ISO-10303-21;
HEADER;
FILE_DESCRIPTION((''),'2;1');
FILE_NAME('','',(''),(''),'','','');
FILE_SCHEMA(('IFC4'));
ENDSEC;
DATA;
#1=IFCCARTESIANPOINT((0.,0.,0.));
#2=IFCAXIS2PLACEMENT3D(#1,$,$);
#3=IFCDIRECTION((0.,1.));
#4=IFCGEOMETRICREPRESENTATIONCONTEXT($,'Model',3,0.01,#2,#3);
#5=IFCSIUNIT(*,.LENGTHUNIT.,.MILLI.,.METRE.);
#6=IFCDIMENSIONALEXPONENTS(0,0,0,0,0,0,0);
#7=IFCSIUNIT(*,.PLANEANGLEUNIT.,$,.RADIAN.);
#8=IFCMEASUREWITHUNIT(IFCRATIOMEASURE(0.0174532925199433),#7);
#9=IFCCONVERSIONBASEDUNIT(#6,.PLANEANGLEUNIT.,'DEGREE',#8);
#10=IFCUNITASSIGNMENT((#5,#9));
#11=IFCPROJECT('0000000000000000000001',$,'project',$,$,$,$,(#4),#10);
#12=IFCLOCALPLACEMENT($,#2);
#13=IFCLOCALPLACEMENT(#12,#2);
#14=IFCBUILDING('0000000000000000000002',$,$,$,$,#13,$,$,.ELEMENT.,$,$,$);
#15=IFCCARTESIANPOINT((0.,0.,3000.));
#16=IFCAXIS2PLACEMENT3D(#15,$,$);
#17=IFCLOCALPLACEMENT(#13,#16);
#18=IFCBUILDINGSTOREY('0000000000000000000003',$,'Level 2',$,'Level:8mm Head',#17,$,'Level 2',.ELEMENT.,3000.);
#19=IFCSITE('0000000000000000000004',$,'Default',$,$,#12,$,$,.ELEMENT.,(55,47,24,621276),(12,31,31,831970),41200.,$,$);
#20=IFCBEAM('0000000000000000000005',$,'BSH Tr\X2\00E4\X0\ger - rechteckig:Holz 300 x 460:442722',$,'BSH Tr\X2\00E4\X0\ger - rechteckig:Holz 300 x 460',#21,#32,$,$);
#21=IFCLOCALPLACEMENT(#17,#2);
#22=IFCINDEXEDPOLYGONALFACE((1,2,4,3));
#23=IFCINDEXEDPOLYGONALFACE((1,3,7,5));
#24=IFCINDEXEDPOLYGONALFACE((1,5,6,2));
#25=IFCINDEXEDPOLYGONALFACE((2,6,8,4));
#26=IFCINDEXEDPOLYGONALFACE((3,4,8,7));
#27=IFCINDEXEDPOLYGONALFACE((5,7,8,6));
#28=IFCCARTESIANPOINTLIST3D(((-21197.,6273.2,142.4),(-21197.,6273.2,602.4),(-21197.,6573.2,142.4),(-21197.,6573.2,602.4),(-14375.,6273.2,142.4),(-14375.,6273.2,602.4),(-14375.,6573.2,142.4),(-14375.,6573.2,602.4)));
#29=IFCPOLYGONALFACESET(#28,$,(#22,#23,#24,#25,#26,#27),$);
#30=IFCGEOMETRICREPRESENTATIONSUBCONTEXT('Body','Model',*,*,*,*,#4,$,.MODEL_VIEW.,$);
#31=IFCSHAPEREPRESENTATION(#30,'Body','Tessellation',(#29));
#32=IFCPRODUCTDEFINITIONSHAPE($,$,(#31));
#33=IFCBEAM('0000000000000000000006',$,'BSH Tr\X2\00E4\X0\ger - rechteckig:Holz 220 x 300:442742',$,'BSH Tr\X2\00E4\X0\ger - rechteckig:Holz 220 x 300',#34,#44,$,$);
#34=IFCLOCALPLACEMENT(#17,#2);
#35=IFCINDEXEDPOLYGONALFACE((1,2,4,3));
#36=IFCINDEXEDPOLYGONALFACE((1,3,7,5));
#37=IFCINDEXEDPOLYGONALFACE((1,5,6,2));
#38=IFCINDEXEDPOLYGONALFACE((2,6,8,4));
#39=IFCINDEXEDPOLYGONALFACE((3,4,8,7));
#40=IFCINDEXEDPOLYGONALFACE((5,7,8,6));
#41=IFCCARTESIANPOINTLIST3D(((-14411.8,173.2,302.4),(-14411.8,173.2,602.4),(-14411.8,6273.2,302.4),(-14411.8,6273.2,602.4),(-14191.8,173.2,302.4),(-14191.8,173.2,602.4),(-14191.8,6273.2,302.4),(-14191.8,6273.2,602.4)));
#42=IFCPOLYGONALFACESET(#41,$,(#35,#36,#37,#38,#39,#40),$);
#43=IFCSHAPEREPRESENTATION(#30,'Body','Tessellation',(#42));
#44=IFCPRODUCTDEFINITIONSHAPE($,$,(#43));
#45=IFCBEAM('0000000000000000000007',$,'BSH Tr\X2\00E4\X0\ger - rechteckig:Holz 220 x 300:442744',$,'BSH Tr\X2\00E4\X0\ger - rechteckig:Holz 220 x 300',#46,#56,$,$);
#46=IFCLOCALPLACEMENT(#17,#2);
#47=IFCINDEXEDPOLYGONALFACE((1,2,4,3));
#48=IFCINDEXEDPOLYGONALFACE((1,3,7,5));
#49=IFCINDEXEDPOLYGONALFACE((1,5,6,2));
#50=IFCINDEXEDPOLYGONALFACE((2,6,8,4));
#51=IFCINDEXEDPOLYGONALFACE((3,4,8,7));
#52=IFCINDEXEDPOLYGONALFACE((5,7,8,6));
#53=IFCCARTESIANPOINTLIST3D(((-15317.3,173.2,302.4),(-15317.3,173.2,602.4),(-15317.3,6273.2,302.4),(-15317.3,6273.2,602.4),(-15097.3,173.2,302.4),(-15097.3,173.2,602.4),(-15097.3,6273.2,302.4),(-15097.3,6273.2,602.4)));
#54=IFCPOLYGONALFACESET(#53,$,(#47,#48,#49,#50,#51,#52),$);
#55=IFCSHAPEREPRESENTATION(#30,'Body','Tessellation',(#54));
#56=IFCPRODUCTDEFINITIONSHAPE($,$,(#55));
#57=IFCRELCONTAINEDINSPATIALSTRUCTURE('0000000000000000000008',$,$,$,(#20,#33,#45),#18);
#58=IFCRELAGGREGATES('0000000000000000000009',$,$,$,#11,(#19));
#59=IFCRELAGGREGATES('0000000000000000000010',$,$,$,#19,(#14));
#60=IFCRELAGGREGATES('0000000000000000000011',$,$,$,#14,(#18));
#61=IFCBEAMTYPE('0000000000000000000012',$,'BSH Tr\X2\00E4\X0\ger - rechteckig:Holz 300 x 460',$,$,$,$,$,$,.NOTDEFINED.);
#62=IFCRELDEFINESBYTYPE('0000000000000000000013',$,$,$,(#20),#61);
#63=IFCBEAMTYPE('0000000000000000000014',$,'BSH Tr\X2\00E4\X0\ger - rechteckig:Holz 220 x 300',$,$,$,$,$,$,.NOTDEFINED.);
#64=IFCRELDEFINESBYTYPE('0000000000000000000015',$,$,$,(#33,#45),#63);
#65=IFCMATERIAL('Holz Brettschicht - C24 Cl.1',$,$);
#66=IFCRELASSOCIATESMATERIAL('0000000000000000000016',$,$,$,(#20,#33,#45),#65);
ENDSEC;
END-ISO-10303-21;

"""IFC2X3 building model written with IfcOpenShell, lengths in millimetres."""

from ifc_helpers import new_model, entity, si_unit, converted_unit, direction, frame, frame_2d, origin, place, context, subcontext, project, spatial, rectangle, extrude, material, type_object, element, save


model = new_model("IFC2X3")

# Units and contexts
model_context = context("Model", 3, precision=0.01, world=origin(), true_north=direction((0.0, 1.0)))
body_context = subcontext(model_context, "Body", "Model", "MODEL_VIEW")
ifc_project = project(units=[si_unit("LENGTHUNIT", "METRE", prefix="MILLI"), converted_unit("PLANEANGLEUNIT", "DEGREE", entity("IfcRatioMeasure", 0.0174532925199433), si_unit("PLANEANGLEUNIT", "RADIAN"), dimensions=[0, 0, 0, 0, 0, 0, 0])], contexts=[model_context])

# Site, building, storey
site_placement = place(None, origin())
site = spatial("IfcSite", under=ifc_project, at=site_placement, Name="Default", CompositionType="ELEMENT", RefLatitude=(55, 47, 24, 621276), RefLongitude=(12, 31, 31, 831970), RefElevation=41200.0)
building_placement = place(site_placement, origin())
building = spatial("IfcBuilding", under=site, at=building_placement, CompositionType="ELEMENT")
storey_placement = place(building_placement, frame((0.0, 0.0, 3000.0)))
storey = spatial("IfcBuildingStorey", under=building, at=storey_placement, Name="Level 2", ObjectType="Level:8mm Head", LongName="Level 2", CompositionType="ELEMENT", Elevation=3000.0)

# Shared definitions
ifc_material_1 = material(Name="Holz Brettschicht - C24 Cl.1")

# Beams
beam_type_1 = type_object("IfcBeamType", Name="BSH Träger - rechteckig:Holz 300 x 460", PredefinedType="NOTDEFINED")
beam_1_placement = place(storey_placement, frame((-14041.8, 6423.2, 602.4), z_axis=(0.0, 0.0, 1.0), x_axis=(-1.0, 0.0, 0.0)))
element("IfcBeam", 1, at=beam_1_placement, inside=storey, type_object=beam_type_1, material=ifc_material_1, Name="BSH Träger - rechteckig:Holz 300 x 460:442722", ObjectType="BSH Träger - rechteckig:Holz 300 x 460", context=body_context, shape_type="SweptSolid", body=[
    extrude(rectangle(XDim=460.0, YDim=300.0, at=frame_2d((0.0, 0.0), x_axis=(1.0, 0.0))), frame((333.2, 0.0, -230.0), z_axis=(1.0, 0.0, 0.0), x_axis=(0.0, 0.0, -1.0)), (0.0, 0.0, 1.0), 6822.0),
])
beam_type_2 = type_object("IfcBeamType", Name="BSH Träger - rechteckig:Holz 220 x 300", PredefinedType="NOTDEFINED")
for number, where, z_axis, x_axis, name in (
    (2, (-14301.8, 6423.2, 602.4), (0.0, 0.0, 1.0), (0.0, -1.0, 0.0), "BSH Träger - rechteckig:Holz 220 x 300:442742"),
    (3, (-15207.3, 6423.2, 602.4), (0.0, 0.0, 1.0), (0.0, -1.0, 0.0), "BSH Träger - rechteckig:Holz 220 x 300:442744"),
):
    element("IfcBeam", number, at=place(storey_placement, frame(where, z_axis=z_axis, x_axis=x_axis)), inside=storey, type_object=beam_type_2, material=ifc_material_1, Name=name, ObjectType="BSH Träger - rechteckig:Holz 220 x 300", context=body_context, shape_type="SweptSolid", body=[
        extrude(rectangle(XDim=300.0, YDim=220.0, at=frame_2d((0.0, 0.0), x_axis=(1.0, 0.0))), frame((150.0, 0.0, -150.0), z_axis=(1.0, 0.0, 0.0), x_axis=(0.0, 0.0, -1.0)), (0.0, 0.0, 1.0), 6100.0),
    ])

save(model, "model.ifc")
